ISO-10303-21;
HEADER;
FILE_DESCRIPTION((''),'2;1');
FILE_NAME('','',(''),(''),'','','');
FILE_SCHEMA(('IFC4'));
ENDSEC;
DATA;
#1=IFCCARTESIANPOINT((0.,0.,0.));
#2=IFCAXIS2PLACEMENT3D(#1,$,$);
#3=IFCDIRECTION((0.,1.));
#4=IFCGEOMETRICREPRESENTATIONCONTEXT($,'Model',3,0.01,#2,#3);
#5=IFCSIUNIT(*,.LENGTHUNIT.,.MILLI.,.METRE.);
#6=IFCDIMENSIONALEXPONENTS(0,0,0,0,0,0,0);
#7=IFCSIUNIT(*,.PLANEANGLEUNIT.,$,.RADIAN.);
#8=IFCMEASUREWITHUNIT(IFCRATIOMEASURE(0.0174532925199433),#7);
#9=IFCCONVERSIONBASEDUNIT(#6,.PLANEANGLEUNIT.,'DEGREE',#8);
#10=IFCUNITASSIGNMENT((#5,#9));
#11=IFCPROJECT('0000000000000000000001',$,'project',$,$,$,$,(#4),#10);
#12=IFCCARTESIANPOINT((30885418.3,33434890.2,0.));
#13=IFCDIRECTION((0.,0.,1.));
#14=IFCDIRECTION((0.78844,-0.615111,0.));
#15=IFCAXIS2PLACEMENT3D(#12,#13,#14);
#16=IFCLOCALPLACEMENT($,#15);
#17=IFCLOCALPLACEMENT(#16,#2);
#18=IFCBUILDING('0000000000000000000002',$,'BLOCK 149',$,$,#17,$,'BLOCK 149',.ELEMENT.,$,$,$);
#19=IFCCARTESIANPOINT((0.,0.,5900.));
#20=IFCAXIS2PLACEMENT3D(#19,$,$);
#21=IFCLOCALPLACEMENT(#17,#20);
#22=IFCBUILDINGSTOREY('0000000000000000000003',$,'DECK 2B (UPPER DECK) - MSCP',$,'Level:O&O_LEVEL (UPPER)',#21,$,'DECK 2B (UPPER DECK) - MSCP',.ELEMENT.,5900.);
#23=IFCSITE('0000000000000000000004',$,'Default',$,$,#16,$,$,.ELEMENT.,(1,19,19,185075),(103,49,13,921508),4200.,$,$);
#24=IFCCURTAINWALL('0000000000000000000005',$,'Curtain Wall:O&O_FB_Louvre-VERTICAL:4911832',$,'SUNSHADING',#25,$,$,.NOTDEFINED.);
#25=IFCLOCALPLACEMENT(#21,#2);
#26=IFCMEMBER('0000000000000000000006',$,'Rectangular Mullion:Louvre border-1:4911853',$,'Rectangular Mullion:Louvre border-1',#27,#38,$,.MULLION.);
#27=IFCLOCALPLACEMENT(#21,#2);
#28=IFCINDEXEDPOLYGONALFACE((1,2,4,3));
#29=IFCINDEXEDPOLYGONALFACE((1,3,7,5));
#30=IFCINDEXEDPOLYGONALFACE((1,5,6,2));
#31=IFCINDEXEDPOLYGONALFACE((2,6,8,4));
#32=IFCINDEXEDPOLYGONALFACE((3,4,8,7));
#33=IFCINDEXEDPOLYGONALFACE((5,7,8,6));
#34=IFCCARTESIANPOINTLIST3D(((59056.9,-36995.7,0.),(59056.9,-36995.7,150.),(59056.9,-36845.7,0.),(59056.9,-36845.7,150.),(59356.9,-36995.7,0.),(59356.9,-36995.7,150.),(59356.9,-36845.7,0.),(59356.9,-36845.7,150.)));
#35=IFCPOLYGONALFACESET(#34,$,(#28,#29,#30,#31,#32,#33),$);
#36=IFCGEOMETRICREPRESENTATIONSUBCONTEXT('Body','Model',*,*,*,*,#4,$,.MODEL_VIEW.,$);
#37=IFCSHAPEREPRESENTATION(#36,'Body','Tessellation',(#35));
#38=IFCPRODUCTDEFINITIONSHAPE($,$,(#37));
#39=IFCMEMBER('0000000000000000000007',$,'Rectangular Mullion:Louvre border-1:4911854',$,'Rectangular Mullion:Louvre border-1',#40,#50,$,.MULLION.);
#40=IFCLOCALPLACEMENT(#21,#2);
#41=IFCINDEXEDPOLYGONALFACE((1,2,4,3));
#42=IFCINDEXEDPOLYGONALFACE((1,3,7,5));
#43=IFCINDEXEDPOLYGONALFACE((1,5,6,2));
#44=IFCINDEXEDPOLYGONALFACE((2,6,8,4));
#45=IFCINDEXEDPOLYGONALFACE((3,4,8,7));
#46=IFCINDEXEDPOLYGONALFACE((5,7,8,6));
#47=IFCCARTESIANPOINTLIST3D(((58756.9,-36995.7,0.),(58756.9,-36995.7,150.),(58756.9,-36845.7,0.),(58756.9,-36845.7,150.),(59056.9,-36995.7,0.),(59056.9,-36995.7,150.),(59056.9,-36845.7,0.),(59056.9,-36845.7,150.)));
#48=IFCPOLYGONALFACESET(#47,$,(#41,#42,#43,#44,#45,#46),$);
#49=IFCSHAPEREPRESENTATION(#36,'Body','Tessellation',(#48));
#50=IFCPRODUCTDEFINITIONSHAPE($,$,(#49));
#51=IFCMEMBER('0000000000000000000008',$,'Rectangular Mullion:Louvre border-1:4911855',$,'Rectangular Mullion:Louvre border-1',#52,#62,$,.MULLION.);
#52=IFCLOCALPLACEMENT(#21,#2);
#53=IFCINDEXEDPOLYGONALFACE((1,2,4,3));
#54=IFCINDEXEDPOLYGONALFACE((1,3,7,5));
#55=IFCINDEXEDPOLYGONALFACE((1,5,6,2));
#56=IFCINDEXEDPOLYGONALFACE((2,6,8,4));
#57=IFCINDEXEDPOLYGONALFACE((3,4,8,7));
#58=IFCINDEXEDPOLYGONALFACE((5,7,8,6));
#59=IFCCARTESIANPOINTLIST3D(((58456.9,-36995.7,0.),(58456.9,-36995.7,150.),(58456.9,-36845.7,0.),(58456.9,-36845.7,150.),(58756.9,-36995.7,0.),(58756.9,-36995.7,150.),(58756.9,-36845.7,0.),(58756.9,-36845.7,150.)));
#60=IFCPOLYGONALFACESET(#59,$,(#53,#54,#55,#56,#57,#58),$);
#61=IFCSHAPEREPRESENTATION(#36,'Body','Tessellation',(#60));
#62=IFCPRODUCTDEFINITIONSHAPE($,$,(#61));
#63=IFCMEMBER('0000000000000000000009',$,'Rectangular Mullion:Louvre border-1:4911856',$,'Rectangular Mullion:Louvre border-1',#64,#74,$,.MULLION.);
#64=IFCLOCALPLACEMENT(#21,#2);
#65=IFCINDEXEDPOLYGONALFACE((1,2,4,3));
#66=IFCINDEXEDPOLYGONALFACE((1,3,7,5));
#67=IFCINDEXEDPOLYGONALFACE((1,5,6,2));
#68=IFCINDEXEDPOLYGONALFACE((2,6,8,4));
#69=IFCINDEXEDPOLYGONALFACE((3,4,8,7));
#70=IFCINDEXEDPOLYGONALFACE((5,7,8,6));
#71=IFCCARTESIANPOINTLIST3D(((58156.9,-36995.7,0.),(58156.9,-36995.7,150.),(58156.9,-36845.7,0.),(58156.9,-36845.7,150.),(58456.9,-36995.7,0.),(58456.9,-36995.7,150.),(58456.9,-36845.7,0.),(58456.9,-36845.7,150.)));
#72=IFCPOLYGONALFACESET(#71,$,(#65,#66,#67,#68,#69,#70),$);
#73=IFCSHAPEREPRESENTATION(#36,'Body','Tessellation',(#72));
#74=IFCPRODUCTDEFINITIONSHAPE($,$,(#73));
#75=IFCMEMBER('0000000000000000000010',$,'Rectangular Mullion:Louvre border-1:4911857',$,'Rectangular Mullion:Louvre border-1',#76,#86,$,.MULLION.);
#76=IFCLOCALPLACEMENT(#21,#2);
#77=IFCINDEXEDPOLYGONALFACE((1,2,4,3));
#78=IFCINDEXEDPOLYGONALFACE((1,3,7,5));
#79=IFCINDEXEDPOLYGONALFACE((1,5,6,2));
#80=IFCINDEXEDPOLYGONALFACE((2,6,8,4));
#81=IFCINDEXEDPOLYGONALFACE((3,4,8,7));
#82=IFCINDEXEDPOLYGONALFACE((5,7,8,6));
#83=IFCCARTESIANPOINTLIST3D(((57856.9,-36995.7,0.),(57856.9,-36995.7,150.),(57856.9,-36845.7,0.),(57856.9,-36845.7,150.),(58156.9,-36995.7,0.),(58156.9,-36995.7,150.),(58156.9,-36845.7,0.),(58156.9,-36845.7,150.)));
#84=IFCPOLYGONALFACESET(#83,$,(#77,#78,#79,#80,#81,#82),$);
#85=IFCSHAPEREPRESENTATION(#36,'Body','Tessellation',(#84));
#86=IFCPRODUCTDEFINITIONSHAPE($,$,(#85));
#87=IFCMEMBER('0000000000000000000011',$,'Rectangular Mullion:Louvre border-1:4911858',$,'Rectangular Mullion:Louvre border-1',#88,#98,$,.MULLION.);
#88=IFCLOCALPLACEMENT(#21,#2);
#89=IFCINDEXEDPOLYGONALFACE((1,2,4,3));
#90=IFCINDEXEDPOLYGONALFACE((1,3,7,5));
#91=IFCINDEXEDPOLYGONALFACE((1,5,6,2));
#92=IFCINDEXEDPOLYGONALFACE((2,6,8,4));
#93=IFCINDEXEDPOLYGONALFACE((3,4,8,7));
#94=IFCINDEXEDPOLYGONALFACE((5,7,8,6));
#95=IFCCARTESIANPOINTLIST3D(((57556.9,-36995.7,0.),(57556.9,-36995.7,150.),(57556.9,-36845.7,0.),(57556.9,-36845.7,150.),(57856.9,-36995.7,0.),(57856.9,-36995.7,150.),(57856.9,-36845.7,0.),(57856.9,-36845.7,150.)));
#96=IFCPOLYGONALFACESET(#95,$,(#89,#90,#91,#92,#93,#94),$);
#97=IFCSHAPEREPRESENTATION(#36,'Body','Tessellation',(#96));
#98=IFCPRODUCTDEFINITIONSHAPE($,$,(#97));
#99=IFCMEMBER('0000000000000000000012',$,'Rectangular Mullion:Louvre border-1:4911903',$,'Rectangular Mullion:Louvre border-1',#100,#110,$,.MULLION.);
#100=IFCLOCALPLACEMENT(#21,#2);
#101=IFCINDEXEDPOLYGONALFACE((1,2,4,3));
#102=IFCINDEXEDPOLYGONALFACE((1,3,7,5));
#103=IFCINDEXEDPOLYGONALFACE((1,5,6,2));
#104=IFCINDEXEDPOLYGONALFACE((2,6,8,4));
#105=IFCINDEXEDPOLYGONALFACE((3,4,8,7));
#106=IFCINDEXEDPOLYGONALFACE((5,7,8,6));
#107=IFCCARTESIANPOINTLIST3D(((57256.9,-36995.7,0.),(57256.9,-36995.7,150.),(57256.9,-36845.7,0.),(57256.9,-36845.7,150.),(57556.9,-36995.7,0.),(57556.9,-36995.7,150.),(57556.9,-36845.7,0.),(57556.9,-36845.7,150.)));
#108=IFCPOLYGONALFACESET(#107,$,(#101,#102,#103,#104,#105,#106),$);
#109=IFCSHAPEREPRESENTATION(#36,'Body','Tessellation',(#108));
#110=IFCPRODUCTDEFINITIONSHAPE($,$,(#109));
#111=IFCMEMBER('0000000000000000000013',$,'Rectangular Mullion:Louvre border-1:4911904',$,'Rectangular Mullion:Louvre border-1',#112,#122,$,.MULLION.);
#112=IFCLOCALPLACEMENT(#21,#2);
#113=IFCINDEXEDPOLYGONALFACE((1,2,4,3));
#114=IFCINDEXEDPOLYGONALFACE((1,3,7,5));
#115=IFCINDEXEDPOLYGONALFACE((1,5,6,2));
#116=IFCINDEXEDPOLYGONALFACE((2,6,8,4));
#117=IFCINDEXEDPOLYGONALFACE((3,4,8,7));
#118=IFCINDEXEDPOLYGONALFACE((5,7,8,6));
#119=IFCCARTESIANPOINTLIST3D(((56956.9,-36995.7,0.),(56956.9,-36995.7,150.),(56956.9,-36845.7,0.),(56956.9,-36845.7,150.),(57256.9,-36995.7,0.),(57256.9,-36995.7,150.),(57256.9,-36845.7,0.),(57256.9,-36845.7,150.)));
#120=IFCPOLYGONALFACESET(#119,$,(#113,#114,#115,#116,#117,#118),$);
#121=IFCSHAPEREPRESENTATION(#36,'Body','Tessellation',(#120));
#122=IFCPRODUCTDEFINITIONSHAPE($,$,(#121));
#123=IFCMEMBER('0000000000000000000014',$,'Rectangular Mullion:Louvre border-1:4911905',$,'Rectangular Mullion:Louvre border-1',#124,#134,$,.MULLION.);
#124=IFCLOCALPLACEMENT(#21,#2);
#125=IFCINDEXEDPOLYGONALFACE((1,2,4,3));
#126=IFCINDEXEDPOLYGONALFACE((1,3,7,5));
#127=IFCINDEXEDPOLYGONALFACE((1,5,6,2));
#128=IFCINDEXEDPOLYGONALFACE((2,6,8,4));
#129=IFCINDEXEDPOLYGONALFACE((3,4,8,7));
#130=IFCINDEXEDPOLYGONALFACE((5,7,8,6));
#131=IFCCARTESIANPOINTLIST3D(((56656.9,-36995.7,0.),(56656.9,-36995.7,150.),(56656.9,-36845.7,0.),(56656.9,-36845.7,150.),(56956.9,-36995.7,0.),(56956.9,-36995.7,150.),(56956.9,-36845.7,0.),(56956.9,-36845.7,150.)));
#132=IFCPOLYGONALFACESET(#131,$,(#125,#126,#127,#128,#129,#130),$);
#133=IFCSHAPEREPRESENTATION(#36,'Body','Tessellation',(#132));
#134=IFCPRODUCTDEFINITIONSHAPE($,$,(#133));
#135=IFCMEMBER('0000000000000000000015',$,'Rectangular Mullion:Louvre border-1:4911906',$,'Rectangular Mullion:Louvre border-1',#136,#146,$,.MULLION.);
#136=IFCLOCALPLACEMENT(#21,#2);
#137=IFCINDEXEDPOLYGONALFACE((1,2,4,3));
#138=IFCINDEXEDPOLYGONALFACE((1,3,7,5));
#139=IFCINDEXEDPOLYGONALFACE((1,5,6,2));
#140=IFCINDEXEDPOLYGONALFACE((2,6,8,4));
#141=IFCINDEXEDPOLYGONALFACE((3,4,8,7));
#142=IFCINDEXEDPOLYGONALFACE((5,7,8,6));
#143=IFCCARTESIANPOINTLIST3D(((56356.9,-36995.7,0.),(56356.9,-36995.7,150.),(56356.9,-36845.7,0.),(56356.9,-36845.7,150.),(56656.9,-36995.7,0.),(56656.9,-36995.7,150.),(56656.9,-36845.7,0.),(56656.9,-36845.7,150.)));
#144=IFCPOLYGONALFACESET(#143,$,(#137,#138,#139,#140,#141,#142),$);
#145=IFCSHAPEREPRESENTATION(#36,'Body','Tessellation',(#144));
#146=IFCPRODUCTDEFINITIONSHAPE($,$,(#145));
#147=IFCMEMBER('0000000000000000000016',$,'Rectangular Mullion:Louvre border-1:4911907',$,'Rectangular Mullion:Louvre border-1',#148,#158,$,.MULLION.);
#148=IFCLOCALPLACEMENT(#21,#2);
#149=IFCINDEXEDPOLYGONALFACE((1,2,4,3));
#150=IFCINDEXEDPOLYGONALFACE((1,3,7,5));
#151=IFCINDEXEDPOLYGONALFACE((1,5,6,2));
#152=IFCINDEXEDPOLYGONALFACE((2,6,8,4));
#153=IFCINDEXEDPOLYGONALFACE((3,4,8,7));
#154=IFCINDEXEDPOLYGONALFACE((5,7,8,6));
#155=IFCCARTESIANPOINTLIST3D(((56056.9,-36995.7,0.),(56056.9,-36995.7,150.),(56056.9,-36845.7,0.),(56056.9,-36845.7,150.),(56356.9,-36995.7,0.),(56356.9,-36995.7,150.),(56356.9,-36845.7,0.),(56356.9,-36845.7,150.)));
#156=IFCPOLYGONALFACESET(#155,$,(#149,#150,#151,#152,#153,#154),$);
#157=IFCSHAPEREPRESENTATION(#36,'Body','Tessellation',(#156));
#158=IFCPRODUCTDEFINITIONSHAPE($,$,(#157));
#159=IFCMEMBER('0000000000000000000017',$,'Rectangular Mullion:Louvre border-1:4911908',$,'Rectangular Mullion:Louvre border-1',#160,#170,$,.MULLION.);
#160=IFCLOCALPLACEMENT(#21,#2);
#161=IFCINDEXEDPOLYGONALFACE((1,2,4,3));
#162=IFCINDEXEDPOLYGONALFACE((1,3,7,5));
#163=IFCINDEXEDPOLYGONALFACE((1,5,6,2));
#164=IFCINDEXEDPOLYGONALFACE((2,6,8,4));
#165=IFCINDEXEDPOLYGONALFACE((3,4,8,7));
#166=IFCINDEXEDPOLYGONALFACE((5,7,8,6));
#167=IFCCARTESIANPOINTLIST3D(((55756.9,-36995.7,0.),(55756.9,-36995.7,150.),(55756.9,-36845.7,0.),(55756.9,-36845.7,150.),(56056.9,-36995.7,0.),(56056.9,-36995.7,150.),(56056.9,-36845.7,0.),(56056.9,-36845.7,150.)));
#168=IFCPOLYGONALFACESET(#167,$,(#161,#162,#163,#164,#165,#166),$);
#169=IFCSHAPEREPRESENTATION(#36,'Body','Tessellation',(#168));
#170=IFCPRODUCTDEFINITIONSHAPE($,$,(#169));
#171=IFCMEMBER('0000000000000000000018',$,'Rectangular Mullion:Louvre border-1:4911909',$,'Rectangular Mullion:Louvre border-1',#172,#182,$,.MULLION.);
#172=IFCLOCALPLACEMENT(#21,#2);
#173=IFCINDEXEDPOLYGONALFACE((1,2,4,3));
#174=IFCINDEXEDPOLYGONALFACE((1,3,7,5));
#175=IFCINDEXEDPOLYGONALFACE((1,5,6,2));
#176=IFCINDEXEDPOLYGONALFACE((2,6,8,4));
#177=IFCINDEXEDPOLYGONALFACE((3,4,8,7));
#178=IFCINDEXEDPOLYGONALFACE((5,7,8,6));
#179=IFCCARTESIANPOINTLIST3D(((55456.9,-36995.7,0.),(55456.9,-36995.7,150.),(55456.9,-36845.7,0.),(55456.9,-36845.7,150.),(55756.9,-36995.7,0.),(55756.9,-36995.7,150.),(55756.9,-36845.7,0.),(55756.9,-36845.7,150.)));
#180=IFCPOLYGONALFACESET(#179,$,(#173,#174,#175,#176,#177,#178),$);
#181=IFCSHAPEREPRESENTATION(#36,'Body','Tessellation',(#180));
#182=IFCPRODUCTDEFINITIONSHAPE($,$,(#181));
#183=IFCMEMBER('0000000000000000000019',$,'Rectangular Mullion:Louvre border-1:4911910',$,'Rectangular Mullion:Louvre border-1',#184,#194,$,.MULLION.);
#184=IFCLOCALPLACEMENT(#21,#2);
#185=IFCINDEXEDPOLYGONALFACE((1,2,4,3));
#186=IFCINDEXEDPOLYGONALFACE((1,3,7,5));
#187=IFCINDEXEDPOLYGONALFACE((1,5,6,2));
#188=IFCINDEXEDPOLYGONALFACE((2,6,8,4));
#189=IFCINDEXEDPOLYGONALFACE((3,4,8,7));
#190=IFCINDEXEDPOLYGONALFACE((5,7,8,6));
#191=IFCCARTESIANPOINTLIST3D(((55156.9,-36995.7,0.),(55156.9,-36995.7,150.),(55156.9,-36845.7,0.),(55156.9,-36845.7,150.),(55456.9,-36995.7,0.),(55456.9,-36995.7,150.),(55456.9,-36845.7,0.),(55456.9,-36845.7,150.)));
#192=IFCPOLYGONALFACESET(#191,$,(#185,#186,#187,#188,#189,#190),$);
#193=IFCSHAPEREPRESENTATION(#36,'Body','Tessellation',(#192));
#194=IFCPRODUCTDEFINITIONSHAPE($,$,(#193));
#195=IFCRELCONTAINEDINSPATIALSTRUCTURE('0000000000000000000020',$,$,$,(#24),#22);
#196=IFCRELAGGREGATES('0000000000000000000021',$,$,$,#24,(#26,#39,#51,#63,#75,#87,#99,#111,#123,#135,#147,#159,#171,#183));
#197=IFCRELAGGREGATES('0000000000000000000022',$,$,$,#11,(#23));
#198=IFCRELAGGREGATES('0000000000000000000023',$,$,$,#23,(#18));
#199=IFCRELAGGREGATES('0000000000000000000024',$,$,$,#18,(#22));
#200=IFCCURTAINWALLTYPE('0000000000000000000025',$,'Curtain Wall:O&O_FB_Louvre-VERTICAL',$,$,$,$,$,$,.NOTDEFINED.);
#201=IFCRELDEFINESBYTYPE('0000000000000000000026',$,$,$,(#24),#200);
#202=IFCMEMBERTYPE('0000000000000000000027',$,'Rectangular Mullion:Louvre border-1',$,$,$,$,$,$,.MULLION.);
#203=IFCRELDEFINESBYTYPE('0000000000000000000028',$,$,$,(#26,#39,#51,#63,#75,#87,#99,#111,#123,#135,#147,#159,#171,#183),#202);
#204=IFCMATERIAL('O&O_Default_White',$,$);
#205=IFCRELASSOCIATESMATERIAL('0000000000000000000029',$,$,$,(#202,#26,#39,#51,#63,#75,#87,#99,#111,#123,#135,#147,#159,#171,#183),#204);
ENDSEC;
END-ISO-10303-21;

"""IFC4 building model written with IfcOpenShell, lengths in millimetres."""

from ifc_helpers import new_model, entity, si_unit, converted_unit, direction, frame, origin, place, context, subcontext, project, spatial, indexed_curve, outline, extrude, source, transform, mapped, material, type_object, type_shapes, element, aggregate, save


model = new_model("IFC4")

# Units and contexts
model_context = context("Model", 3, precision=0.01, world=origin(), true_north=direction((0.0, 1.0)))
body_context = subcontext(model_context, "Body", "Model", "MODEL_VIEW")
ifc_project = project(units=[si_unit("LENGTHUNIT", "METRE", prefix="MILLI"), converted_unit("PLANEANGLEUNIT", "DEGREE", entity("IfcRatioMeasure", 0.0174532925199433), si_unit("PLANEANGLEUNIT", "RADIAN"), dimensions=[0, 0, 0, 0, 0, 0, 0])], contexts=[model_context])

# Site, building, storey
site_placement = place(None, frame((30885418.3, 33434890.2, 0.0), z_axis=(0.0, 0.0, 1.0), x_axis=(0.78844, -0.615111, 0.0)))
site = spatial("IfcSite", under=ifc_project, at=site_placement, Name="Default", CompositionType="ELEMENT", RefLatitude=(1, 19, 19, 185075), RefLongitude=(103, 49, 13, 921508), RefElevation=4200.0)
building_placement = place(site_placement, origin())
building = spatial("IfcBuilding", under=site, at=building_placement, Name="BLOCK 149", LongName="BLOCK 149", CompositionType="ELEMENT")
storey_placement = place(building_placement, frame((0.0, 0.0, 5900.0)))
storey = spatial("IfcBuildingStorey", under=building, at=storey_placement, Name="DECK 2B (UPPER DECK) - MSCP", ObjectType="Level:O&O_LEVEL (UPPER)", LongName="DECK 2B (UPPER DECK) - MSCP", CompositionType="ELEMENT", Elevation=5900.0)

# Curtain wall, members
curtain_wall_type = type_object("IfcCurtainWallType", Name="Curtain Wall:O&O_FB_Louvre-VERTICAL", PredefinedType="NOTDEFINED")
curtain_wall_placement = place(storey_placement, frame((0.0, 0.0, -5900.0)))
curtain_wall = element("IfcCurtainWall", 1, at=curtain_wall_placement, inside=storey, type_object=curtain_wall_type, Name="Curtain Wall:O&O_FB_Louvre-VERTICAL:4911832", ObjectType="SUNSHADING", PredefinedType="NOTDEFINED")
ifc_material_1 = material(Name="O&O_Default_White")
placement = place(building_placement, origin())
member_type_1 = type_object("IfcMemberType", Name="Rectangular Mullion:Louvre border-1", PredefinedType="MULLION", material=ifc_material_1)
shared_shape_1 = source(origin(), body_context, "Body", "SweptSolid", [
    extrude(outline(indexed_curve([(-75.0, -75.0), (75.0, -75.0), (75.0, 75.0), (-75.0, 75.0), (-75.0, -75.0)], self_intersect=False)), frame((-75.0, 0.0, -300.0), z_axis=(0.0, 0.0, 1.0), x_axis=(0.0, -1.0, 0.0)), (0.0, 0.0, 1.0), 300.0),
])
type_shapes(member_type_1, [shared_shape_1])
member_1_placement = place(placement, frame((59356.9, -36920.7, 5900.0), z_axis=(1.0, 0.0, 0.0), x_axis=(0.0, 0.0, -1.0)))
member_1 = element("IfcMember", 2, at=member_1_placement, type_object=member_type_1, material=ifc_material_1, Name="Rectangular Mullion:Louvre border-1:4911853", ObjectType="Rectangular Mullion:Louvre border-1", PredefinedType="MULLION", context=body_context, shape_type="MappedRepresentation", body=[
    mapped(shared_shape_1, transform((0.0, 0.0, 0.0), scale=1.0)),
])
member_2_placement = place(placement, frame((59056.9, -36920.7, 5900.0), z_axis=(1.0, 0.0, 0.0), x_axis=(0.0, 0.0, -1.0)))
member_2 = element("IfcMember", 3, at=member_2_placement, type_object=member_type_1, material=ifc_material_1, Name="Rectangular Mullion:Louvre border-1:4911854", ObjectType="Rectangular Mullion:Louvre border-1", PredefinedType="MULLION", context=body_context, shape_type="MappedRepresentation", body=[
    mapped(shared_shape_1, transform((0.0, 0.0, 0.0), scale=1.0)),
])
member_3_placement = place(placement, frame((58756.9, -36920.7, 5900.0), z_axis=(1.0, 0.0, 0.0), x_axis=(0.0, 0.0, -1.0)))
member_3 = element("IfcMember", 4, at=member_3_placement, type_object=member_type_1, material=ifc_material_1, Name="Rectangular Mullion:Louvre border-1:4911855", ObjectType="Rectangular Mullion:Louvre border-1", PredefinedType="MULLION", context=body_context, shape_type="MappedRepresentation", body=[
    mapped(shared_shape_1, transform((0.0, 0.0, 0.0), scale=1.0)),
])
member_4_placement = place(placement, frame((58456.9, -36920.7, 5900.0), z_axis=(1.0, 0.0, 0.0), x_axis=(0.0, 0.0, -1.0)))
member_4 = element("IfcMember", 5, at=member_4_placement, type_object=member_type_1, material=ifc_material_1, Name="Rectangular Mullion:Louvre border-1:4911856", ObjectType="Rectangular Mullion:Louvre border-1", PredefinedType="MULLION", context=body_context, shape_type="MappedRepresentation", body=[
    mapped(shared_shape_1, transform((0.0, 0.0, 0.0), scale=1.0)),
])
member_5_placement = place(placement, frame((58156.9, -36920.7, 5900.0), z_axis=(1.0, 0.0, 0.0), x_axis=(0.0, 0.0, -1.0)))
member_5 = element("IfcMember", 6, at=member_5_placement, type_object=member_type_1, material=ifc_material_1, Name="Rectangular Mullion:Louvre border-1:4911857", ObjectType="Rectangular Mullion:Louvre border-1", PredefinedType="MULLION", context=body_context, shape_type="MappedRepresentation", body=[
    mapped(shared_shape_1, transform((0.0, 0.0, 0.0), scale=1.0)),
])
member_6_placement = place(placement, frame((57856.9, -36920.7, 5900.0), z_axis=(1.0, 0.0, 0.0), x_axis=(0.0, 0.0, -1.0)))
member_6 = element("IfcMember", 7, at=member_6_placement, type_object=member_type_1, material=ifc_material_1, Name="Rectangular Mullion:Louvre border-1:4911858", ObjectType="Rectangular Mullion:Louvre border-1", PredefinedType="MULLION", context=body_context, shape_type="MappedRepresentation", body=[
    mapped(shared_shape_1, transform((0.0, 0.0, 0.0), scale=1.0)),
])
member_7_placement = place(placement, frame((57556.9, -36920.7, 5900.0), z_axis=(1.0, 0.0, 0.0), x_axis=(0.0, 0.0, -1.0)))
member_7 = element("IfcMember", 8, at=member_7_placement, type_object=member_type_1, material=ifc_material_1, Name="Rectangular Mullion:Louvre border-1:4911903", ObjectType="Rectangular Mullion:Louvre border-1", PredefinedType="MULLION", context=body_context, shape_type="MappedRepresentation", body=[
    mapped(shared_shape_1, transform((0.0, 0.0, 0.0), scale=1.0)),
])
member_8_placement = place(placement, frame((57256.9, -36920.7, 5900.0), z_axis=(1.0, 0.0, 0.0), x_axis=(0.0, 0.0, -1.0)))
member_8 = element("IfcMember", 9, at=member_8_placement, type_object=member_type_1, material=ifc_material_1, Name="Rectangular Mullion:Louvre border-1:4911904", ObjectType="Rectangular Mullion:Louvre border-1", PredefinedType="MULLION", context=body_context, shape_type="MappedRepresentation", body=[
    mapped(shared_shape_1, transform((0.0, 0.0, 0.0), scale=1.0)),
])
member_9_placement = place(placement, frame((56956.9, -36920.7, 5900.0), z_axis=(1.0, 0.0, 0.0), x_axis=(0.0, 0.0, -1.0)))
member_9 = element("IfcMember", 10, at=member_9_placement, type_object=member_type_1, material=ifc_material_1, Name="Rectangular Mullion:Louvre border-1:4911905", ObjectType="Rectangular Mullion:Louvre border-1", PredefinedType="MULLION", context=body_context, shape_type="MappedRepresentation", body=[
    mapped(shared_shape_1, transform((0.0, 0.0, 0.0), scale=1.0)),
])
member_10_placement = place(placement, frame((56656.9, -36920.7, 5900.0), z_axis=(1.0, 0.0, 0.0), x_axis=(0.0, 0.0, -1.0)))
member_10 = element("IfcMember", 11, at=member_10_placement, type_object=member_type_1, material=ifc_material_1, Name="Rectangular Mullion:Louvre border-1:4911906", ObjectType="Rectangular Mullion:Louvre border-1", PredefinedType="MULLION", context=body_context, shape_type="MappedRepresentation", body=[
    mapped(shared_shape_1, transform((0.0, 0.0, 0.0), scale=1.0)),
])
member_11_placement = place(placement, frame((56356.9, -36920.7, 5900.0), z_axis=(1.0, 0.0, 0.0), x_axis=(0.0, 0.0, -1.0)))
member_11 = element("IfcMember", 12, at=member_11_placement, type_object=member_type_1, material=ifc_material_1, Name="Rectangular Mullion:Louvre border-1:4911907", ObjectType="Rectangular Mullion:Louvre border-1", PredefinedType="MULLION", context=body_context, shape_type="MappedRepresentation", body=[
    mapped(shared_shape_1, transform((0.0, 0.0, 0.0), scale=1.0)),
])
member_12_placement = place(placement, frame((56056.9, -36920.7, 5900.0), z_axis=(1.0, 0.0, 0.0), x_axis=(0.0, 0.0, -1.0)))
member_12 = element("IfcMember", 13, at=member_12_placement, type_object=member_type_1, material=ifc_material_1, Name="Rectangular Mullion:Louvre border-1:4911908", ObjectType="Rectangular Mullion:Louvre border-1", PredefinedType="MULLION", context=body_context, shape_type="MappedRepresentation", body=[
    mapped(shared_shape_1, transform((0.0, 0.0, 0.0), scale=1.0)),
])
member_13_placement = place(placement, frame((55756.9, -36920.7, 5900.0), z_axis=(1.0, 0.0, 0.0), x_axis=(0.0, 0.0, -1.0)))
member_13 = element("IfcMember", 14, at=member_13_placement, type_object=member_type_1, material=ifc_material_1, Name="Rectangular Mullion:Louvre border-1:4911909", ObjectType="Rectangular Mullion:Louvre border-1", PredefinedType="MULLION", context=body_context, shape_type="MappedRepresentation", body=[
    mapped(shared_shape_1, transform((0.0, 0.0, 0.0), scale=1.0)),
])
member_14_placement = place(placement, frame((55456.9, -36920.7, 5900.0), z_axis=(1.0, 0.0, 0.0), x_axis=(0.0, 0.0, -1.0)))
member_14 = element("IfcMember", 15, at=member_14_placement, type_object=member_type_1, material=ifc_material_1, Name="Rectangular Mullion:Louvre border-1:4911910", ObjectType="Rectangular Mullion:Louvre border-1", PredefinedType="MULLION", context=body_context, shape_type="MappedRepresentation", body=[
    mapped(shared_shape_1, transform((0.0, 0.0, 0.0), scale=1.0)),
])
aggregate(curtain_wall, [member_1, member_2, member_3, member_4, member_5, member_6, member_7, member_8, member_9, member_10, member_11, member_12, member_13, member_14])

save(model, "model.ifc")
